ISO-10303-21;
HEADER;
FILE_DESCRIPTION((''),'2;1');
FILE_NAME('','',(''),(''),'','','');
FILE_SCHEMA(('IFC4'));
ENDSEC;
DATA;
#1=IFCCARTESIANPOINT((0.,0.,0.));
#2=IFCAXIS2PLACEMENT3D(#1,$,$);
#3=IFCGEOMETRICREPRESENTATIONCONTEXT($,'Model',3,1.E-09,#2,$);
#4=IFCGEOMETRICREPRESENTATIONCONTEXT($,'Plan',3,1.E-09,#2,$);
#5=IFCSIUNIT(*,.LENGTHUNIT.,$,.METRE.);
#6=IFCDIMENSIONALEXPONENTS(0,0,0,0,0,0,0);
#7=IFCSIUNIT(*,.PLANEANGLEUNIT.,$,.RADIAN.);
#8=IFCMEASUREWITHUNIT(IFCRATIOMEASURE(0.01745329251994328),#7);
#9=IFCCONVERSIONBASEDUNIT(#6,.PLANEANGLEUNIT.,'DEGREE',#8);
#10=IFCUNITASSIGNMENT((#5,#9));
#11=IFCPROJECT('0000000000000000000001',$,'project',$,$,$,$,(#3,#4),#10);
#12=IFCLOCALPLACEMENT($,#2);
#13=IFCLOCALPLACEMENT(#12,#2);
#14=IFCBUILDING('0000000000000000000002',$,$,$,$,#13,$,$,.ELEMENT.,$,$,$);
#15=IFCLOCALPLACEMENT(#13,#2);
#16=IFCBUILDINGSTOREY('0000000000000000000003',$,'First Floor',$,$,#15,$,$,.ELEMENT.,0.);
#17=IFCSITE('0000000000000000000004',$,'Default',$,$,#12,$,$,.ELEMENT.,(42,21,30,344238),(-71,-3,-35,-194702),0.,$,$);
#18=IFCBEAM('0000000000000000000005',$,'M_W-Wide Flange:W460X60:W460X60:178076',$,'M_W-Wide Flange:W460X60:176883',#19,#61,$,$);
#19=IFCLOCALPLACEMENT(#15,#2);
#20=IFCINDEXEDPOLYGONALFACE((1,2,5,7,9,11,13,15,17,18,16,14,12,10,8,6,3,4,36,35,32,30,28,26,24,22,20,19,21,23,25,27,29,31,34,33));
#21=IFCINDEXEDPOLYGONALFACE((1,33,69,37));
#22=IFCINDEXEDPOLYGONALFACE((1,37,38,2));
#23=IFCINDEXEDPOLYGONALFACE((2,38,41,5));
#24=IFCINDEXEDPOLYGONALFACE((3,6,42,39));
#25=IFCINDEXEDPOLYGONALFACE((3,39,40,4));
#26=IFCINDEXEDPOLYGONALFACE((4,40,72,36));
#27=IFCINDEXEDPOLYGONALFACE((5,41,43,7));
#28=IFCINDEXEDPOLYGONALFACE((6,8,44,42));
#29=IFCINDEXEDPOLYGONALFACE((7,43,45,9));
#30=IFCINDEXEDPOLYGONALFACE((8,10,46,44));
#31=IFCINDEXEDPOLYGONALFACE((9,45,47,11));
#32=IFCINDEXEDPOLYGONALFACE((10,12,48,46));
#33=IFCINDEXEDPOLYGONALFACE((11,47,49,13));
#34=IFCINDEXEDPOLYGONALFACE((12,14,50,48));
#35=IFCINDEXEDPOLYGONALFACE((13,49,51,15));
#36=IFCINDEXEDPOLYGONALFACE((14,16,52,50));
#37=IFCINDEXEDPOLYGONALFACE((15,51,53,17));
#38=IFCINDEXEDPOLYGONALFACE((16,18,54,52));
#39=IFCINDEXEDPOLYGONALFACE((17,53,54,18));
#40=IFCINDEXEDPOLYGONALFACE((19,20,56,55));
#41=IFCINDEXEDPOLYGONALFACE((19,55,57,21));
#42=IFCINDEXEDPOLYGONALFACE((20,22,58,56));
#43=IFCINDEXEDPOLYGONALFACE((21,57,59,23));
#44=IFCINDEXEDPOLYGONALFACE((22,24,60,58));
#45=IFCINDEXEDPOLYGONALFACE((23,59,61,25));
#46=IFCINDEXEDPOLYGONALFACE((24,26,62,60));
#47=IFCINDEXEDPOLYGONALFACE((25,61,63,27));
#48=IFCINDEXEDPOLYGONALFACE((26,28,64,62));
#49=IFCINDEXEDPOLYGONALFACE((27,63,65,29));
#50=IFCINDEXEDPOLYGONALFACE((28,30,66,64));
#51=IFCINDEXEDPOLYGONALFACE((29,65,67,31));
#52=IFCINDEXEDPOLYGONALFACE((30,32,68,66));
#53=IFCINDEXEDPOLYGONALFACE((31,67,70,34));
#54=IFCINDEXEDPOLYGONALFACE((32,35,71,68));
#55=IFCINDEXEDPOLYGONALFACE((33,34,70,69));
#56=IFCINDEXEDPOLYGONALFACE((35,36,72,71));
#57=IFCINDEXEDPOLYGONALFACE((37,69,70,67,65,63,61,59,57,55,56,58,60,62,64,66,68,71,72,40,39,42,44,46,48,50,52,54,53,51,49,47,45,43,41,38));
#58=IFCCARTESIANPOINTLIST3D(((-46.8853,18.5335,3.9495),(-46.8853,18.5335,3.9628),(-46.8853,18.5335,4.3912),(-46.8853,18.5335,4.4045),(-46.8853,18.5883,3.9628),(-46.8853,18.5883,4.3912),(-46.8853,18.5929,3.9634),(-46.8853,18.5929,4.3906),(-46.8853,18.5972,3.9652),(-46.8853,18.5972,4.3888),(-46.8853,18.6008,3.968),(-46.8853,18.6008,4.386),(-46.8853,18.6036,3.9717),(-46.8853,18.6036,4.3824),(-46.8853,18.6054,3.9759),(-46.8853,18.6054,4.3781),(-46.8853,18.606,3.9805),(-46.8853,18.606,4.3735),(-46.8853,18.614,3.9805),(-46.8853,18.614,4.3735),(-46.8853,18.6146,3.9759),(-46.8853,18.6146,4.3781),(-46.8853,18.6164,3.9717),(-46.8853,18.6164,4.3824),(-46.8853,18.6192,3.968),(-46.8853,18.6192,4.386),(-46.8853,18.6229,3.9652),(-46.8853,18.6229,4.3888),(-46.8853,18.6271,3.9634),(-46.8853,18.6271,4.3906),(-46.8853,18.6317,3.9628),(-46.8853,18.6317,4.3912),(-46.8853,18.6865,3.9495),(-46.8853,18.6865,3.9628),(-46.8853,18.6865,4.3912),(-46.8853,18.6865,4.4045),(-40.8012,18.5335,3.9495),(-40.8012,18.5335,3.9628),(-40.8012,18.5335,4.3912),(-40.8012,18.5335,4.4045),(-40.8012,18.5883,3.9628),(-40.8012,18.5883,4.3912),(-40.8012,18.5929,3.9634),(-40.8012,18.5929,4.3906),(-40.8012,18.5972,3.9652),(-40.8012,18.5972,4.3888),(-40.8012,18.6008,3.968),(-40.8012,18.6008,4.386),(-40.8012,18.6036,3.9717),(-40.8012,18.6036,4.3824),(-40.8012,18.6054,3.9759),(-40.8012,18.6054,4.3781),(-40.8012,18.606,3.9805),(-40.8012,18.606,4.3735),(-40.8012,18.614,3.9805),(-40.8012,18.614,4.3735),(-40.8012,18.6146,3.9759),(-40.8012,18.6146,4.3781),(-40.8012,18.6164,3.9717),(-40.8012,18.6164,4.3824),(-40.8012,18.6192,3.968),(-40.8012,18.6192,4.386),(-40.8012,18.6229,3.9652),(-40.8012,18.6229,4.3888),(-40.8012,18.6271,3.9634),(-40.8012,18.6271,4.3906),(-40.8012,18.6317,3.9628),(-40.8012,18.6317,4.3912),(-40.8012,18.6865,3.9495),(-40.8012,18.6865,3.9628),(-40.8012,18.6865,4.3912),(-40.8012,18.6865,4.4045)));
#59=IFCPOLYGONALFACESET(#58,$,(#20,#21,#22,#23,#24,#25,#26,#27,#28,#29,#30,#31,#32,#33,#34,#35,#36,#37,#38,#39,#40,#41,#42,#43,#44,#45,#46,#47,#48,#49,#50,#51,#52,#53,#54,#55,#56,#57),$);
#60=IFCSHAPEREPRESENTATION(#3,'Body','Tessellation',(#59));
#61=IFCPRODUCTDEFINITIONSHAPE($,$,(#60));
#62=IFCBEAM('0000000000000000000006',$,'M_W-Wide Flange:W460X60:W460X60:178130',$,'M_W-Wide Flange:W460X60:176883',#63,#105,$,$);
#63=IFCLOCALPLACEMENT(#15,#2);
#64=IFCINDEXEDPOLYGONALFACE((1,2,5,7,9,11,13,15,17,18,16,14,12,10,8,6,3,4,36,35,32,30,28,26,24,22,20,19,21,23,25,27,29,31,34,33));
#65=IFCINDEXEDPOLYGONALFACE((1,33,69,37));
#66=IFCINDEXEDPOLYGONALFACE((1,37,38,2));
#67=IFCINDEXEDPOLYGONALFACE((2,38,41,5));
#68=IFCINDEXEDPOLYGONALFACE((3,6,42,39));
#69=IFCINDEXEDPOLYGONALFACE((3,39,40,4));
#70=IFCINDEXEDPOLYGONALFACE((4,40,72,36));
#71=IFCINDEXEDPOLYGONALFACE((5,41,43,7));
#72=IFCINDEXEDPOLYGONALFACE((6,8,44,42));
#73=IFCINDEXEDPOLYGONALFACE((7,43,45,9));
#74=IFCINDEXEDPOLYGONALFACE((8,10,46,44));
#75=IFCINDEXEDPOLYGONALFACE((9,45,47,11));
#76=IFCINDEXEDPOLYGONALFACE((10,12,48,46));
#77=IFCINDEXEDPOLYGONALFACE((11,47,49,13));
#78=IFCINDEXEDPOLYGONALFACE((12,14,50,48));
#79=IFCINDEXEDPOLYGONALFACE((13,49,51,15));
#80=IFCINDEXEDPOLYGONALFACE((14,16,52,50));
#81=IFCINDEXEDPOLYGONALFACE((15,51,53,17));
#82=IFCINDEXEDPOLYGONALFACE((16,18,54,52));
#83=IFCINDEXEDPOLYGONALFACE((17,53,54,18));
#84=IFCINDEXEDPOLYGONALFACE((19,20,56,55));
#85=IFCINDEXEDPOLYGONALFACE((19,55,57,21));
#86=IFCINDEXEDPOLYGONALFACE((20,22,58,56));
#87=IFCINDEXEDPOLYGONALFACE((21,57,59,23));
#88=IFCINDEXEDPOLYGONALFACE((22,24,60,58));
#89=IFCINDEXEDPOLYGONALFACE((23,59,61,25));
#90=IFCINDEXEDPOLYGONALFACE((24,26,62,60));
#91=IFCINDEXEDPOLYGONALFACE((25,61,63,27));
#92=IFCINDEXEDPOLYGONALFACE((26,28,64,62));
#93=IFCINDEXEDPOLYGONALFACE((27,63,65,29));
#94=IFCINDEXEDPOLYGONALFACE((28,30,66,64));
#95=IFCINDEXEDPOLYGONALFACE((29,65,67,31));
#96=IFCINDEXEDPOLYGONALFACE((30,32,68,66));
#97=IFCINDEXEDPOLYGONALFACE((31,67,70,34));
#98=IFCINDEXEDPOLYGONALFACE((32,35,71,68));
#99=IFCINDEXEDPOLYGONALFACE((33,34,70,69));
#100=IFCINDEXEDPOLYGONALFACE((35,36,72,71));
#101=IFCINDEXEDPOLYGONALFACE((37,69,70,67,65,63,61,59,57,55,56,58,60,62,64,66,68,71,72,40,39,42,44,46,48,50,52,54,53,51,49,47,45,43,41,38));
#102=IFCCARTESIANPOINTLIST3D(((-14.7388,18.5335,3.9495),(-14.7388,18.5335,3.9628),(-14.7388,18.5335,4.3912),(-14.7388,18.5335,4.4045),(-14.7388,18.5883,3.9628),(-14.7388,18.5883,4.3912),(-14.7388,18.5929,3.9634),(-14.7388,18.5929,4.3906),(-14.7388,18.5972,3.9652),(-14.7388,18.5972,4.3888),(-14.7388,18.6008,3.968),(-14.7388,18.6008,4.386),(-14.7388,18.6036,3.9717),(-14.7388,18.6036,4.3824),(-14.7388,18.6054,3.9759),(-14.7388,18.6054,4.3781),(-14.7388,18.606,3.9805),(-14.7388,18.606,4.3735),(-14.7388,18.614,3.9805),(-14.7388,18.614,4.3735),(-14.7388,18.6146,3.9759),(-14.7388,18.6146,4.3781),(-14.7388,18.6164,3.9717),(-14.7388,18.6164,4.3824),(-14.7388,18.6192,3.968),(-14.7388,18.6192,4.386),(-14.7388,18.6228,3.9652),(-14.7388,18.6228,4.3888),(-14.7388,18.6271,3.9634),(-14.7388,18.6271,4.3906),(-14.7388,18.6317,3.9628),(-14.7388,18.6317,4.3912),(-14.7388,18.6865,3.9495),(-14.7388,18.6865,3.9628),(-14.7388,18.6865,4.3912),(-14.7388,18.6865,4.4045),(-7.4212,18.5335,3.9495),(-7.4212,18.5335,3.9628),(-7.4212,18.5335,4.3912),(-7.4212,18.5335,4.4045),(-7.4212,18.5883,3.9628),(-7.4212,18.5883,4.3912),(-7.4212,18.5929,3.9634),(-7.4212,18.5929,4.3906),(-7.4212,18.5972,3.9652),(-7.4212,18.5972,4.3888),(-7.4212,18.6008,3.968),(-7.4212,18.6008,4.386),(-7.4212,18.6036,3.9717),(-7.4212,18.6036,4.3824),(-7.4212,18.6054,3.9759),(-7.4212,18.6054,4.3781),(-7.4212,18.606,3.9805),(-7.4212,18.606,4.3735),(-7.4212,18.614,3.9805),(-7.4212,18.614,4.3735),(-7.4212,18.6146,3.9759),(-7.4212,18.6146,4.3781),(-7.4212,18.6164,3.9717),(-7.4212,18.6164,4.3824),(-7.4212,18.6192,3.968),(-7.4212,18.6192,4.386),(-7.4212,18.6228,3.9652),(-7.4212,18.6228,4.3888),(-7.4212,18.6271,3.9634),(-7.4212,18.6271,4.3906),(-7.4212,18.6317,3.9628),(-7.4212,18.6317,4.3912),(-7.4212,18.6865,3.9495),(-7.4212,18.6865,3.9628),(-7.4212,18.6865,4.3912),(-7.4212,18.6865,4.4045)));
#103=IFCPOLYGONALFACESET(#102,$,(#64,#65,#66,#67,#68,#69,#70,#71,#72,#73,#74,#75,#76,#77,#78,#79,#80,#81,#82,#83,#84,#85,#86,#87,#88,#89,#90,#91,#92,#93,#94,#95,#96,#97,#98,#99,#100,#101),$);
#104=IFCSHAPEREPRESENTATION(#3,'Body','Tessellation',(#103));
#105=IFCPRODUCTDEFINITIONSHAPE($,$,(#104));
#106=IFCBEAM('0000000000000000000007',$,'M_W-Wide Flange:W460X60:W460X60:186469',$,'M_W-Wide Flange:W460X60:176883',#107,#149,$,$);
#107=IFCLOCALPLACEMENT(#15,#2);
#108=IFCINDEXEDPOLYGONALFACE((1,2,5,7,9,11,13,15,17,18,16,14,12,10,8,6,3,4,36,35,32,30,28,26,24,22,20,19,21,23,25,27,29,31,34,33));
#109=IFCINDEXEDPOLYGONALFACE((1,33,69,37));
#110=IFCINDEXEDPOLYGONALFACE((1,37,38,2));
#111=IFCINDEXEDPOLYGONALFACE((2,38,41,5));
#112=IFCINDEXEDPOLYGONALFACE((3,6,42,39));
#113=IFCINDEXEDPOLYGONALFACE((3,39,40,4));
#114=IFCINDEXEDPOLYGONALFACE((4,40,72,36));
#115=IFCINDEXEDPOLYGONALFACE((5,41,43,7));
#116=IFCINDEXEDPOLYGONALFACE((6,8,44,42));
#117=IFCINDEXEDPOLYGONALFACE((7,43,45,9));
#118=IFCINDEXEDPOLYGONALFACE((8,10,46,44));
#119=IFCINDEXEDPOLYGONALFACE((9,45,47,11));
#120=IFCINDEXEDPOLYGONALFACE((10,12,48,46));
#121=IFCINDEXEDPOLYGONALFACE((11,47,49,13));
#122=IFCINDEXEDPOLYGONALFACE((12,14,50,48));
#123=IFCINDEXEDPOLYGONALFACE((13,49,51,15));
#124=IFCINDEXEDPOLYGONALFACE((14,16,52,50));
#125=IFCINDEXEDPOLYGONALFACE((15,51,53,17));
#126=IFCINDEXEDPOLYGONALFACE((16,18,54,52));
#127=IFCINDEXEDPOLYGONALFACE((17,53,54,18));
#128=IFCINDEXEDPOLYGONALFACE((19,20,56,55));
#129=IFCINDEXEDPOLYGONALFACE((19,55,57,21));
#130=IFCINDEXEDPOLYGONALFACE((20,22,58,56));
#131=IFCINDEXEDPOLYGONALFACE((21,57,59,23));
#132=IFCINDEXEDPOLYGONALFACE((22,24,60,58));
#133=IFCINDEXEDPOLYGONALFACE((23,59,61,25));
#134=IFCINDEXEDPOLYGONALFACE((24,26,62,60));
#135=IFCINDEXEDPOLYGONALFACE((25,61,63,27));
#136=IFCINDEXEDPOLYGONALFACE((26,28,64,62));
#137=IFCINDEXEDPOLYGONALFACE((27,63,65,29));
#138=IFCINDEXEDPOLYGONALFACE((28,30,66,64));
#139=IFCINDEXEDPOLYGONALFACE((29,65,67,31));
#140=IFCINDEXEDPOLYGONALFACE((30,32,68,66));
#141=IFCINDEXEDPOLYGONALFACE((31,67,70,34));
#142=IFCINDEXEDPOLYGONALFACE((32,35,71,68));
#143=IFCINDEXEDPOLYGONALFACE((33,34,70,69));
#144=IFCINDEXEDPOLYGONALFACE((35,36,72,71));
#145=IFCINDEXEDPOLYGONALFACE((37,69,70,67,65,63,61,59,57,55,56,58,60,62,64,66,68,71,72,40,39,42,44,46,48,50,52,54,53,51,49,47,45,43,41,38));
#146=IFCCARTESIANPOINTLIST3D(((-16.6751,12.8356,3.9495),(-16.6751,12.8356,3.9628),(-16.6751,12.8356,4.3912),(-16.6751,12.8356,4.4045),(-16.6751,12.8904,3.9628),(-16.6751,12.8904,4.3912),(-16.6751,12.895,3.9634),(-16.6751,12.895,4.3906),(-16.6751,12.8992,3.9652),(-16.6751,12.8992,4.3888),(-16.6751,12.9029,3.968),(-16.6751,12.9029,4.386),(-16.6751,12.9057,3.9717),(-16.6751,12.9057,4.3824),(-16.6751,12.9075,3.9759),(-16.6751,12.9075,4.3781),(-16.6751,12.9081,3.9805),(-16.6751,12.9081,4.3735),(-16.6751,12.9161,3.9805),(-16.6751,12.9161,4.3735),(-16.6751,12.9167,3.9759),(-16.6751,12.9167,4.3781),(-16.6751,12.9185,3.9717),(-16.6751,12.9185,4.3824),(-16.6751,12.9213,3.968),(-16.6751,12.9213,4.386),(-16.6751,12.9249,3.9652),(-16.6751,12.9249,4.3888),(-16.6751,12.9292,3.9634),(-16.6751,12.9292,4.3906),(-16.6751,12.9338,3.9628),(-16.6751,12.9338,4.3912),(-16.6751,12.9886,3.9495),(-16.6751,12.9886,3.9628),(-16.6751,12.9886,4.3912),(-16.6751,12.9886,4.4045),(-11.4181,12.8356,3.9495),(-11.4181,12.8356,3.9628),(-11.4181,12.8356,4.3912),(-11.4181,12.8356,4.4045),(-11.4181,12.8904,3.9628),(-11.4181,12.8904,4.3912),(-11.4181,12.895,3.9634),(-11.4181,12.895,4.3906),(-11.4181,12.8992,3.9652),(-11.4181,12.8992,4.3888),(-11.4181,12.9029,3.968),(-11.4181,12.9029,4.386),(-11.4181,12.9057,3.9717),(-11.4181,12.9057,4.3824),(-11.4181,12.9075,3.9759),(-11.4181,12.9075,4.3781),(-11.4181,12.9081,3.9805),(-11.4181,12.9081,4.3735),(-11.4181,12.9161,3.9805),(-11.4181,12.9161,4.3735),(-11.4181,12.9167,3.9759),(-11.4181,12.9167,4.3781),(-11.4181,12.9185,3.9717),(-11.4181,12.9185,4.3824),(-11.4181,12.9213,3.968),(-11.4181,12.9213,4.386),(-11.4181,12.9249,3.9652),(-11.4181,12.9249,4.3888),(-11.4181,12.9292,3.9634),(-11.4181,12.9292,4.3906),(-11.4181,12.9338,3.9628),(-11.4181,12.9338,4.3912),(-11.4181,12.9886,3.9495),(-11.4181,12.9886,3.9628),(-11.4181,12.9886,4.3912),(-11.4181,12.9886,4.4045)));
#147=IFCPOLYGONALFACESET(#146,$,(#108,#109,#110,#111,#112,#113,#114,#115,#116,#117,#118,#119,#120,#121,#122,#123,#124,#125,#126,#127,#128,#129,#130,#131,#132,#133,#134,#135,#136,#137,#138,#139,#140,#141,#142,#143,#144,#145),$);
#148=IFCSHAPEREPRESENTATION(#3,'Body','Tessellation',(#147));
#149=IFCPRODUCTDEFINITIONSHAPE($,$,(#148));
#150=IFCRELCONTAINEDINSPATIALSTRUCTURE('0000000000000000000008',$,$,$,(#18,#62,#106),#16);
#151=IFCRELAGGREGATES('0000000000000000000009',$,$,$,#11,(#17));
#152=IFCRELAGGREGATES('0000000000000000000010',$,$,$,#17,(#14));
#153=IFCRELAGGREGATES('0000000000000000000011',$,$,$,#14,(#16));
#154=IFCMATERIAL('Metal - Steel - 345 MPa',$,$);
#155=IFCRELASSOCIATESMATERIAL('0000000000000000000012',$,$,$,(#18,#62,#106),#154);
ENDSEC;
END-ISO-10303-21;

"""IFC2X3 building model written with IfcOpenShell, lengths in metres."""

from ifc_helpers import new_model, entity, si_unit, converted_unit, frame, frame_2d, origin, place, context, project, spatial, polyline, circle_curve, parameter, trimmed, segment, composite_curve, outline, extrude, material, element, save


model = new_model("IFC2X3")

# Units and contexts
model_context = context("Model", 3, precision=1e-09, world=origin())
plan_context = context("Plan", 3, precision=1e-09, world=origin())
ifc_project = project(units=[si_unit("LENGTHUNIT", "METRE"), converted_unit("PLANEANGLEUNIT", "DEGREE", entity("IfcRatioMeasure", 0.01745329251994328), si_unit("PLANEANGLEUNIT", "RADIAN"), dimensions=[0, 0, 0, 0, 0, 0, 0])], contexts=[model_context, plan_context])

# Site, building, storey
site_placement = place(None, origin())
site = spatial("IfcSite", under=ifc_project, at=site_placement, Name="Default", CompositionType="ELEMENT", RefLatitude=(42, 21, 30, 344238), RefLongitude=(-71, -3, -35, -194702), RefElevation=0.0)
building_placement = place(site_placement, origin())
building = spatial("IfcBuilding", under=site, at=building_placement, CompositionType="ELEMENT")
storey_placement = place(building_placement, origin())
storey = spatial("IfcBuildingStorey", under=building, at=storey_placement, Name="First Floor", CompositionType="ELEMENT", Elevation=0.0)

# Beams
ifc_material_1 = material(Name="Metal - Steel - 345 MPa")
beam_1_placement = place(storey_placement, frame((-47.0022, 18.61, 4.4045), z_axis=(0.0, 0.0, 1.0), x_axis=(0.0, -1.0, 0.0)))
element("IfcBeam", 1, at=beam_1_placement, inside=storey, material=ifc_material_1, Name="M_W-Wide Flange:W460X60:W460X60:178076", ObjectType="M_W-Wide Flange:W460X60:176883", context=model_context, shape_type="SweptSolid", body=[
    extrude(outline(composite_curve([segment(polyline([(-0.0765, -0.2142), (-0.0765, -0.2275)]), True, "CONTINUOUS"), segment(polyline([(-0.0765, -0.2275), (0.0765, -0.2275)]), True, "CONTINUOUS"), segment(polyline([(0.0765, -0.2275), (0.0765, -0.2142)]), True, "CONTINUOUS"), segment(polyline([(0.0765, -0.2142), (0.0217, -0.2142)]), True, "CONTINUOUS"), segment(trimmed(circle_curve(frame_2d((0.0217, -0.1965), x_axis=(0.0, -1.0)), 0.0177), [parameter(270.0)], [parameter(360.0)], True, "PARAMETER"), False, "CONTINUOUS"), segment(polyline([(0.004, -0.1965), (0.004, 0.1965)]), True, "CONTINUOUS"), segment(trimmed(circle_curve(frame_2d((0.0217, 0.1965), x_axis=(-1.0, 0.0)), 0.0177), [parameter(270.0)], [parameter(360.0)], True, "PARAMETER"), False, "CONTINUOUS"), segment(polyline([(0.0217, 0.2142), (0.0765, 0.2142)]), True, "CONTINUOUS"), segment(polyline([(0.0765, 0.2142), (0.0765, 0.2275)]), True, "CONTINUOUS"), segment(polyline([(0.0765, 0.2275), (-0.0765, 0.2275)]), True, "CONTINUOUS"), segment(polyline([(-0.0765, 0.2275), (-0.0765, 0.2142)]), True, "CONTINUOUS"), segment(polyline([(-0.0765, 0.2142), (-0.0217, 0.2142)]), True, "CONTINUOUS"), segment(trimmed(circle_curve(frame_2d((-0.0217, 0.1965), x_axis=(0.0, 1.0)), 0.0177), [parameter(270.0)], [parameter(360.0)], True, "PARAMETER"), False, "CONTINUOUS"), segment(polyline([(-0.004, 0.1965), (-0.004, -0.1965)]), True, "CONTINUOUS"), segment(trimmed(circle_curve(frame_2d((-0.0217, -0.1965), x_axis=(1.0, 0.0)), 0.0177), [parameter(270.0)], [parameter(0.0)], True, "PARAMETER"), False, "CONTINUOUS"), segment(polyline([(-0.0217, -0.2142), (-0.0765, -0.2142)]), True, "CONTINUOUS")], self_intersect=False)), frame((0.0, 0.1169, -0.2275), z_axis=(0.0, -1.0, 0.0), x_axis=(1.0, 0.0, 0.0)), (0.0, 0.0, -1.0), 6.0841),
])
beam_2_placement = place(storey_placement, frame((-14.8818, 18.61, 4.4045), z_axis=(0.0, 0.0, 1.0), x_axis=(0.0, -1.0, 0.0)))
element("IfcBeam", 2, at=beam_2_placement, inside=storey, material=ifc_material_1, Name="M_W-Wide Flange:W460X60:W460X60:178130", ObjectType="M_W-Wide Flange:W460X60:176883", context=model_context, shape_type="SweptSolid", body=[
    extrude(outline(composite_curve([segment(polyline([(-0.0765, -0.2142), (-0.0765, -0.2275)]), True, "CONTINUOUS"), segment(polyline([(-0.0765, -0.2275), (0.0765, -0.2275)]), True, "CONTINUOUS"), segment(polyline([(0.0765, -0.2275), (0.0765, -0.2142)]), True, "CONTINUOUS"), segment(polyline([(0.0765, -0.2142), (0.0217, -0.2142)]), True, "CONTINUOUS"), segment(trimmed(circle_curve(frame_2d((0.0217, -0.1965), x_axis=(0.0, -1.0)), 0.0177), [parameter(270.0)], [parameter(360.0)], True, "PARAMETER"), False, "CONTINUOUS"), segment(polyline([(0.004, -0.1965), (0.004, 0.1965)]), True, "CONTINUOUS"), segment(trimmed(circle_curve(frame_2d((0.0217, 0.1965), x_axis=(-1.0, 0.0)), 0.0177), [parameter(270.0)], [parameter(360.0)], True, "PARAMETER"), False, "CONTINUOUS"), segment(polyline([(0.0217, 0.2142), (0.0765, 0.2142)]), True, "CONTINUOUS"), segment(polyline([(0.0765, 0.2142), (0.0765, 0.2275)]), True, "CONTINUOUS"), segment(polyline([(0.0765, 0.2275), (-0.0765, 0.2275)]), True, "CONTINUOUS"), segment(polyline([(-0.0765, 0.2275), (-0.0765, 0.2142)]), True, "CONTINUOUS"), segment(polyline([(-0.0765, 0.2142), (-0.0217, 0.2142)]), True, "CONTINUOUS"), segment(trimmed(circle_curve(frame_2d((-0.0217, 0.1965), x_axis=(0.0, 1.0)), 0.0177), [parameter(270.0)], [parameter(360.0)], True, "PARAMETER"), False, "CONTINUOUS"), segment(polyline([(-0.004, 0.1965), (-0.004, -0.1965)]), True, "CONTINUOUS"), segment(trimmed(circle_curve(frame_2d((-0.0217, -0.1965), x_axis=(1.0, 0.0)), 0.0177), [parameter(270.0)], [parameter(0.0)], True, "PARAMETER"), False, "CONTINUOUS"), segment(polyline([(-0.0217, -0.2142), (-0.0765, -0.2142)]), True, "CONTINUOUS")], self_intersect=False)), frame((0.0, 0.143, -0.2275), z_axis=(0.0, -1.0, 0.0), x_axis=(1.0, 0.0, 0.0)), (0.0, 0.0, -1.0), 7.3176),
])
beam_3_placement = place(storey_placement, frame((-16.5269, 12.9121, 4.4045), z_axis=(0.0, 0.0, 1.0), x_axis=(0.0, -1.0, 0.0)))
element("IfcBeam", 3, at=beam_3_placement, inside=storey, material=ifc_material_1, Name="M_W-Wide Flange:W460X60:W460X60:186469", ObjectType="M_W-Wide Flange:W460X60:176883", context=model_context, shape_type="SweptSolid", body=[
    extrude(outline(composite_curve([segment(polyline([(-0.0765, -0.2142), (-0.0765, -0.2275)]), True, "CONTINUOUS"), segment(polyline([(-0.0765, -0.2275), (0.0765, -0.2275)]), True, "CONTINUOUS"), segment(polyline([(0.0765, -0.2275), (0.0765, -0.2142)]), True, "CONTINUOUS"), segment(polyline([(0.0765, -0.2142), (0.0217, -0.2142)]), True, "CONTINUOUS"), segment(trimmed(circle_curve(frame_2d((0.0217, -0.1965), x_axis=(1.0, 0.0)), 0.0177), [parameter(180.0)], [parameter(270.0)], True, "PARAMETER"), False, "CONTINUOUS"), segment(polyline([(0.004, -0.1965), (0.004, 0.1965)]), True, "CONTINUOUS"), segment(trimmed(circle_curve(frame_2d((0.0217, 0.1965), x_axis=(1.0, 0.0)), 0.0177), [parameter(90.0)], [parameter(180.0)], True, "PARAMETER"), False, "CONTINUOUS"), segment(polyline([(0.0217, 0.2142), (0.0765, 0.2142)]), True, "CONTINUOUS"), segment(polyline([(0.0765, 0.2142), (0.0765, 0.2275)]), True, "CONTINUOUS"), segment(polyline([(0.0765, 0.2275), (-0.0765, 0.2275)]), True, "CONTINUOUS"), segment(polyline([(-0.0765, 0.2275), (-0.0765, 0.2142)]), True, "CONTINUOUS"), segment(polyline([(-0.0765, 0.2142), (-0.0217, 0.2142)]), True, "CONTINUOUS"), segment(trimmed(circle_curve(frame_2d((-0.0217, 0.1965), x_axis=(1.0, 0.0)), 0.0177), [parameter(360.0)], [parameter(90.0)], True, "PARAMETER"), False, "CONTINUOUS"), segment(polyline([(-0.004, 0.1965), (-0.004, -0.1965)]), True, "CONTINUOUS"), segment(trimmed(circle_curve(frame_2d((-0.0217, -0.1965), x_axis=(1.0, 0.0)), 0.0177), [parameter(270.0)], [parameter(0.0)], True, "PARAMETER"), False, "CONTINUOUS"), segment(polyline([(-0.0217, -0.2142), (-0.0765, -0.2142)]), True, "CONTINUOUS")], self_intersect=False)), frame((0.0, -0.1482, -0.2275), z_axis=(0.0, -1.0, 0.0), x_axis=(1.0, 0.0, 0.0)), (0.0, 0.0, -1.0), 5.257),
])

save(model, "model.ifc")
